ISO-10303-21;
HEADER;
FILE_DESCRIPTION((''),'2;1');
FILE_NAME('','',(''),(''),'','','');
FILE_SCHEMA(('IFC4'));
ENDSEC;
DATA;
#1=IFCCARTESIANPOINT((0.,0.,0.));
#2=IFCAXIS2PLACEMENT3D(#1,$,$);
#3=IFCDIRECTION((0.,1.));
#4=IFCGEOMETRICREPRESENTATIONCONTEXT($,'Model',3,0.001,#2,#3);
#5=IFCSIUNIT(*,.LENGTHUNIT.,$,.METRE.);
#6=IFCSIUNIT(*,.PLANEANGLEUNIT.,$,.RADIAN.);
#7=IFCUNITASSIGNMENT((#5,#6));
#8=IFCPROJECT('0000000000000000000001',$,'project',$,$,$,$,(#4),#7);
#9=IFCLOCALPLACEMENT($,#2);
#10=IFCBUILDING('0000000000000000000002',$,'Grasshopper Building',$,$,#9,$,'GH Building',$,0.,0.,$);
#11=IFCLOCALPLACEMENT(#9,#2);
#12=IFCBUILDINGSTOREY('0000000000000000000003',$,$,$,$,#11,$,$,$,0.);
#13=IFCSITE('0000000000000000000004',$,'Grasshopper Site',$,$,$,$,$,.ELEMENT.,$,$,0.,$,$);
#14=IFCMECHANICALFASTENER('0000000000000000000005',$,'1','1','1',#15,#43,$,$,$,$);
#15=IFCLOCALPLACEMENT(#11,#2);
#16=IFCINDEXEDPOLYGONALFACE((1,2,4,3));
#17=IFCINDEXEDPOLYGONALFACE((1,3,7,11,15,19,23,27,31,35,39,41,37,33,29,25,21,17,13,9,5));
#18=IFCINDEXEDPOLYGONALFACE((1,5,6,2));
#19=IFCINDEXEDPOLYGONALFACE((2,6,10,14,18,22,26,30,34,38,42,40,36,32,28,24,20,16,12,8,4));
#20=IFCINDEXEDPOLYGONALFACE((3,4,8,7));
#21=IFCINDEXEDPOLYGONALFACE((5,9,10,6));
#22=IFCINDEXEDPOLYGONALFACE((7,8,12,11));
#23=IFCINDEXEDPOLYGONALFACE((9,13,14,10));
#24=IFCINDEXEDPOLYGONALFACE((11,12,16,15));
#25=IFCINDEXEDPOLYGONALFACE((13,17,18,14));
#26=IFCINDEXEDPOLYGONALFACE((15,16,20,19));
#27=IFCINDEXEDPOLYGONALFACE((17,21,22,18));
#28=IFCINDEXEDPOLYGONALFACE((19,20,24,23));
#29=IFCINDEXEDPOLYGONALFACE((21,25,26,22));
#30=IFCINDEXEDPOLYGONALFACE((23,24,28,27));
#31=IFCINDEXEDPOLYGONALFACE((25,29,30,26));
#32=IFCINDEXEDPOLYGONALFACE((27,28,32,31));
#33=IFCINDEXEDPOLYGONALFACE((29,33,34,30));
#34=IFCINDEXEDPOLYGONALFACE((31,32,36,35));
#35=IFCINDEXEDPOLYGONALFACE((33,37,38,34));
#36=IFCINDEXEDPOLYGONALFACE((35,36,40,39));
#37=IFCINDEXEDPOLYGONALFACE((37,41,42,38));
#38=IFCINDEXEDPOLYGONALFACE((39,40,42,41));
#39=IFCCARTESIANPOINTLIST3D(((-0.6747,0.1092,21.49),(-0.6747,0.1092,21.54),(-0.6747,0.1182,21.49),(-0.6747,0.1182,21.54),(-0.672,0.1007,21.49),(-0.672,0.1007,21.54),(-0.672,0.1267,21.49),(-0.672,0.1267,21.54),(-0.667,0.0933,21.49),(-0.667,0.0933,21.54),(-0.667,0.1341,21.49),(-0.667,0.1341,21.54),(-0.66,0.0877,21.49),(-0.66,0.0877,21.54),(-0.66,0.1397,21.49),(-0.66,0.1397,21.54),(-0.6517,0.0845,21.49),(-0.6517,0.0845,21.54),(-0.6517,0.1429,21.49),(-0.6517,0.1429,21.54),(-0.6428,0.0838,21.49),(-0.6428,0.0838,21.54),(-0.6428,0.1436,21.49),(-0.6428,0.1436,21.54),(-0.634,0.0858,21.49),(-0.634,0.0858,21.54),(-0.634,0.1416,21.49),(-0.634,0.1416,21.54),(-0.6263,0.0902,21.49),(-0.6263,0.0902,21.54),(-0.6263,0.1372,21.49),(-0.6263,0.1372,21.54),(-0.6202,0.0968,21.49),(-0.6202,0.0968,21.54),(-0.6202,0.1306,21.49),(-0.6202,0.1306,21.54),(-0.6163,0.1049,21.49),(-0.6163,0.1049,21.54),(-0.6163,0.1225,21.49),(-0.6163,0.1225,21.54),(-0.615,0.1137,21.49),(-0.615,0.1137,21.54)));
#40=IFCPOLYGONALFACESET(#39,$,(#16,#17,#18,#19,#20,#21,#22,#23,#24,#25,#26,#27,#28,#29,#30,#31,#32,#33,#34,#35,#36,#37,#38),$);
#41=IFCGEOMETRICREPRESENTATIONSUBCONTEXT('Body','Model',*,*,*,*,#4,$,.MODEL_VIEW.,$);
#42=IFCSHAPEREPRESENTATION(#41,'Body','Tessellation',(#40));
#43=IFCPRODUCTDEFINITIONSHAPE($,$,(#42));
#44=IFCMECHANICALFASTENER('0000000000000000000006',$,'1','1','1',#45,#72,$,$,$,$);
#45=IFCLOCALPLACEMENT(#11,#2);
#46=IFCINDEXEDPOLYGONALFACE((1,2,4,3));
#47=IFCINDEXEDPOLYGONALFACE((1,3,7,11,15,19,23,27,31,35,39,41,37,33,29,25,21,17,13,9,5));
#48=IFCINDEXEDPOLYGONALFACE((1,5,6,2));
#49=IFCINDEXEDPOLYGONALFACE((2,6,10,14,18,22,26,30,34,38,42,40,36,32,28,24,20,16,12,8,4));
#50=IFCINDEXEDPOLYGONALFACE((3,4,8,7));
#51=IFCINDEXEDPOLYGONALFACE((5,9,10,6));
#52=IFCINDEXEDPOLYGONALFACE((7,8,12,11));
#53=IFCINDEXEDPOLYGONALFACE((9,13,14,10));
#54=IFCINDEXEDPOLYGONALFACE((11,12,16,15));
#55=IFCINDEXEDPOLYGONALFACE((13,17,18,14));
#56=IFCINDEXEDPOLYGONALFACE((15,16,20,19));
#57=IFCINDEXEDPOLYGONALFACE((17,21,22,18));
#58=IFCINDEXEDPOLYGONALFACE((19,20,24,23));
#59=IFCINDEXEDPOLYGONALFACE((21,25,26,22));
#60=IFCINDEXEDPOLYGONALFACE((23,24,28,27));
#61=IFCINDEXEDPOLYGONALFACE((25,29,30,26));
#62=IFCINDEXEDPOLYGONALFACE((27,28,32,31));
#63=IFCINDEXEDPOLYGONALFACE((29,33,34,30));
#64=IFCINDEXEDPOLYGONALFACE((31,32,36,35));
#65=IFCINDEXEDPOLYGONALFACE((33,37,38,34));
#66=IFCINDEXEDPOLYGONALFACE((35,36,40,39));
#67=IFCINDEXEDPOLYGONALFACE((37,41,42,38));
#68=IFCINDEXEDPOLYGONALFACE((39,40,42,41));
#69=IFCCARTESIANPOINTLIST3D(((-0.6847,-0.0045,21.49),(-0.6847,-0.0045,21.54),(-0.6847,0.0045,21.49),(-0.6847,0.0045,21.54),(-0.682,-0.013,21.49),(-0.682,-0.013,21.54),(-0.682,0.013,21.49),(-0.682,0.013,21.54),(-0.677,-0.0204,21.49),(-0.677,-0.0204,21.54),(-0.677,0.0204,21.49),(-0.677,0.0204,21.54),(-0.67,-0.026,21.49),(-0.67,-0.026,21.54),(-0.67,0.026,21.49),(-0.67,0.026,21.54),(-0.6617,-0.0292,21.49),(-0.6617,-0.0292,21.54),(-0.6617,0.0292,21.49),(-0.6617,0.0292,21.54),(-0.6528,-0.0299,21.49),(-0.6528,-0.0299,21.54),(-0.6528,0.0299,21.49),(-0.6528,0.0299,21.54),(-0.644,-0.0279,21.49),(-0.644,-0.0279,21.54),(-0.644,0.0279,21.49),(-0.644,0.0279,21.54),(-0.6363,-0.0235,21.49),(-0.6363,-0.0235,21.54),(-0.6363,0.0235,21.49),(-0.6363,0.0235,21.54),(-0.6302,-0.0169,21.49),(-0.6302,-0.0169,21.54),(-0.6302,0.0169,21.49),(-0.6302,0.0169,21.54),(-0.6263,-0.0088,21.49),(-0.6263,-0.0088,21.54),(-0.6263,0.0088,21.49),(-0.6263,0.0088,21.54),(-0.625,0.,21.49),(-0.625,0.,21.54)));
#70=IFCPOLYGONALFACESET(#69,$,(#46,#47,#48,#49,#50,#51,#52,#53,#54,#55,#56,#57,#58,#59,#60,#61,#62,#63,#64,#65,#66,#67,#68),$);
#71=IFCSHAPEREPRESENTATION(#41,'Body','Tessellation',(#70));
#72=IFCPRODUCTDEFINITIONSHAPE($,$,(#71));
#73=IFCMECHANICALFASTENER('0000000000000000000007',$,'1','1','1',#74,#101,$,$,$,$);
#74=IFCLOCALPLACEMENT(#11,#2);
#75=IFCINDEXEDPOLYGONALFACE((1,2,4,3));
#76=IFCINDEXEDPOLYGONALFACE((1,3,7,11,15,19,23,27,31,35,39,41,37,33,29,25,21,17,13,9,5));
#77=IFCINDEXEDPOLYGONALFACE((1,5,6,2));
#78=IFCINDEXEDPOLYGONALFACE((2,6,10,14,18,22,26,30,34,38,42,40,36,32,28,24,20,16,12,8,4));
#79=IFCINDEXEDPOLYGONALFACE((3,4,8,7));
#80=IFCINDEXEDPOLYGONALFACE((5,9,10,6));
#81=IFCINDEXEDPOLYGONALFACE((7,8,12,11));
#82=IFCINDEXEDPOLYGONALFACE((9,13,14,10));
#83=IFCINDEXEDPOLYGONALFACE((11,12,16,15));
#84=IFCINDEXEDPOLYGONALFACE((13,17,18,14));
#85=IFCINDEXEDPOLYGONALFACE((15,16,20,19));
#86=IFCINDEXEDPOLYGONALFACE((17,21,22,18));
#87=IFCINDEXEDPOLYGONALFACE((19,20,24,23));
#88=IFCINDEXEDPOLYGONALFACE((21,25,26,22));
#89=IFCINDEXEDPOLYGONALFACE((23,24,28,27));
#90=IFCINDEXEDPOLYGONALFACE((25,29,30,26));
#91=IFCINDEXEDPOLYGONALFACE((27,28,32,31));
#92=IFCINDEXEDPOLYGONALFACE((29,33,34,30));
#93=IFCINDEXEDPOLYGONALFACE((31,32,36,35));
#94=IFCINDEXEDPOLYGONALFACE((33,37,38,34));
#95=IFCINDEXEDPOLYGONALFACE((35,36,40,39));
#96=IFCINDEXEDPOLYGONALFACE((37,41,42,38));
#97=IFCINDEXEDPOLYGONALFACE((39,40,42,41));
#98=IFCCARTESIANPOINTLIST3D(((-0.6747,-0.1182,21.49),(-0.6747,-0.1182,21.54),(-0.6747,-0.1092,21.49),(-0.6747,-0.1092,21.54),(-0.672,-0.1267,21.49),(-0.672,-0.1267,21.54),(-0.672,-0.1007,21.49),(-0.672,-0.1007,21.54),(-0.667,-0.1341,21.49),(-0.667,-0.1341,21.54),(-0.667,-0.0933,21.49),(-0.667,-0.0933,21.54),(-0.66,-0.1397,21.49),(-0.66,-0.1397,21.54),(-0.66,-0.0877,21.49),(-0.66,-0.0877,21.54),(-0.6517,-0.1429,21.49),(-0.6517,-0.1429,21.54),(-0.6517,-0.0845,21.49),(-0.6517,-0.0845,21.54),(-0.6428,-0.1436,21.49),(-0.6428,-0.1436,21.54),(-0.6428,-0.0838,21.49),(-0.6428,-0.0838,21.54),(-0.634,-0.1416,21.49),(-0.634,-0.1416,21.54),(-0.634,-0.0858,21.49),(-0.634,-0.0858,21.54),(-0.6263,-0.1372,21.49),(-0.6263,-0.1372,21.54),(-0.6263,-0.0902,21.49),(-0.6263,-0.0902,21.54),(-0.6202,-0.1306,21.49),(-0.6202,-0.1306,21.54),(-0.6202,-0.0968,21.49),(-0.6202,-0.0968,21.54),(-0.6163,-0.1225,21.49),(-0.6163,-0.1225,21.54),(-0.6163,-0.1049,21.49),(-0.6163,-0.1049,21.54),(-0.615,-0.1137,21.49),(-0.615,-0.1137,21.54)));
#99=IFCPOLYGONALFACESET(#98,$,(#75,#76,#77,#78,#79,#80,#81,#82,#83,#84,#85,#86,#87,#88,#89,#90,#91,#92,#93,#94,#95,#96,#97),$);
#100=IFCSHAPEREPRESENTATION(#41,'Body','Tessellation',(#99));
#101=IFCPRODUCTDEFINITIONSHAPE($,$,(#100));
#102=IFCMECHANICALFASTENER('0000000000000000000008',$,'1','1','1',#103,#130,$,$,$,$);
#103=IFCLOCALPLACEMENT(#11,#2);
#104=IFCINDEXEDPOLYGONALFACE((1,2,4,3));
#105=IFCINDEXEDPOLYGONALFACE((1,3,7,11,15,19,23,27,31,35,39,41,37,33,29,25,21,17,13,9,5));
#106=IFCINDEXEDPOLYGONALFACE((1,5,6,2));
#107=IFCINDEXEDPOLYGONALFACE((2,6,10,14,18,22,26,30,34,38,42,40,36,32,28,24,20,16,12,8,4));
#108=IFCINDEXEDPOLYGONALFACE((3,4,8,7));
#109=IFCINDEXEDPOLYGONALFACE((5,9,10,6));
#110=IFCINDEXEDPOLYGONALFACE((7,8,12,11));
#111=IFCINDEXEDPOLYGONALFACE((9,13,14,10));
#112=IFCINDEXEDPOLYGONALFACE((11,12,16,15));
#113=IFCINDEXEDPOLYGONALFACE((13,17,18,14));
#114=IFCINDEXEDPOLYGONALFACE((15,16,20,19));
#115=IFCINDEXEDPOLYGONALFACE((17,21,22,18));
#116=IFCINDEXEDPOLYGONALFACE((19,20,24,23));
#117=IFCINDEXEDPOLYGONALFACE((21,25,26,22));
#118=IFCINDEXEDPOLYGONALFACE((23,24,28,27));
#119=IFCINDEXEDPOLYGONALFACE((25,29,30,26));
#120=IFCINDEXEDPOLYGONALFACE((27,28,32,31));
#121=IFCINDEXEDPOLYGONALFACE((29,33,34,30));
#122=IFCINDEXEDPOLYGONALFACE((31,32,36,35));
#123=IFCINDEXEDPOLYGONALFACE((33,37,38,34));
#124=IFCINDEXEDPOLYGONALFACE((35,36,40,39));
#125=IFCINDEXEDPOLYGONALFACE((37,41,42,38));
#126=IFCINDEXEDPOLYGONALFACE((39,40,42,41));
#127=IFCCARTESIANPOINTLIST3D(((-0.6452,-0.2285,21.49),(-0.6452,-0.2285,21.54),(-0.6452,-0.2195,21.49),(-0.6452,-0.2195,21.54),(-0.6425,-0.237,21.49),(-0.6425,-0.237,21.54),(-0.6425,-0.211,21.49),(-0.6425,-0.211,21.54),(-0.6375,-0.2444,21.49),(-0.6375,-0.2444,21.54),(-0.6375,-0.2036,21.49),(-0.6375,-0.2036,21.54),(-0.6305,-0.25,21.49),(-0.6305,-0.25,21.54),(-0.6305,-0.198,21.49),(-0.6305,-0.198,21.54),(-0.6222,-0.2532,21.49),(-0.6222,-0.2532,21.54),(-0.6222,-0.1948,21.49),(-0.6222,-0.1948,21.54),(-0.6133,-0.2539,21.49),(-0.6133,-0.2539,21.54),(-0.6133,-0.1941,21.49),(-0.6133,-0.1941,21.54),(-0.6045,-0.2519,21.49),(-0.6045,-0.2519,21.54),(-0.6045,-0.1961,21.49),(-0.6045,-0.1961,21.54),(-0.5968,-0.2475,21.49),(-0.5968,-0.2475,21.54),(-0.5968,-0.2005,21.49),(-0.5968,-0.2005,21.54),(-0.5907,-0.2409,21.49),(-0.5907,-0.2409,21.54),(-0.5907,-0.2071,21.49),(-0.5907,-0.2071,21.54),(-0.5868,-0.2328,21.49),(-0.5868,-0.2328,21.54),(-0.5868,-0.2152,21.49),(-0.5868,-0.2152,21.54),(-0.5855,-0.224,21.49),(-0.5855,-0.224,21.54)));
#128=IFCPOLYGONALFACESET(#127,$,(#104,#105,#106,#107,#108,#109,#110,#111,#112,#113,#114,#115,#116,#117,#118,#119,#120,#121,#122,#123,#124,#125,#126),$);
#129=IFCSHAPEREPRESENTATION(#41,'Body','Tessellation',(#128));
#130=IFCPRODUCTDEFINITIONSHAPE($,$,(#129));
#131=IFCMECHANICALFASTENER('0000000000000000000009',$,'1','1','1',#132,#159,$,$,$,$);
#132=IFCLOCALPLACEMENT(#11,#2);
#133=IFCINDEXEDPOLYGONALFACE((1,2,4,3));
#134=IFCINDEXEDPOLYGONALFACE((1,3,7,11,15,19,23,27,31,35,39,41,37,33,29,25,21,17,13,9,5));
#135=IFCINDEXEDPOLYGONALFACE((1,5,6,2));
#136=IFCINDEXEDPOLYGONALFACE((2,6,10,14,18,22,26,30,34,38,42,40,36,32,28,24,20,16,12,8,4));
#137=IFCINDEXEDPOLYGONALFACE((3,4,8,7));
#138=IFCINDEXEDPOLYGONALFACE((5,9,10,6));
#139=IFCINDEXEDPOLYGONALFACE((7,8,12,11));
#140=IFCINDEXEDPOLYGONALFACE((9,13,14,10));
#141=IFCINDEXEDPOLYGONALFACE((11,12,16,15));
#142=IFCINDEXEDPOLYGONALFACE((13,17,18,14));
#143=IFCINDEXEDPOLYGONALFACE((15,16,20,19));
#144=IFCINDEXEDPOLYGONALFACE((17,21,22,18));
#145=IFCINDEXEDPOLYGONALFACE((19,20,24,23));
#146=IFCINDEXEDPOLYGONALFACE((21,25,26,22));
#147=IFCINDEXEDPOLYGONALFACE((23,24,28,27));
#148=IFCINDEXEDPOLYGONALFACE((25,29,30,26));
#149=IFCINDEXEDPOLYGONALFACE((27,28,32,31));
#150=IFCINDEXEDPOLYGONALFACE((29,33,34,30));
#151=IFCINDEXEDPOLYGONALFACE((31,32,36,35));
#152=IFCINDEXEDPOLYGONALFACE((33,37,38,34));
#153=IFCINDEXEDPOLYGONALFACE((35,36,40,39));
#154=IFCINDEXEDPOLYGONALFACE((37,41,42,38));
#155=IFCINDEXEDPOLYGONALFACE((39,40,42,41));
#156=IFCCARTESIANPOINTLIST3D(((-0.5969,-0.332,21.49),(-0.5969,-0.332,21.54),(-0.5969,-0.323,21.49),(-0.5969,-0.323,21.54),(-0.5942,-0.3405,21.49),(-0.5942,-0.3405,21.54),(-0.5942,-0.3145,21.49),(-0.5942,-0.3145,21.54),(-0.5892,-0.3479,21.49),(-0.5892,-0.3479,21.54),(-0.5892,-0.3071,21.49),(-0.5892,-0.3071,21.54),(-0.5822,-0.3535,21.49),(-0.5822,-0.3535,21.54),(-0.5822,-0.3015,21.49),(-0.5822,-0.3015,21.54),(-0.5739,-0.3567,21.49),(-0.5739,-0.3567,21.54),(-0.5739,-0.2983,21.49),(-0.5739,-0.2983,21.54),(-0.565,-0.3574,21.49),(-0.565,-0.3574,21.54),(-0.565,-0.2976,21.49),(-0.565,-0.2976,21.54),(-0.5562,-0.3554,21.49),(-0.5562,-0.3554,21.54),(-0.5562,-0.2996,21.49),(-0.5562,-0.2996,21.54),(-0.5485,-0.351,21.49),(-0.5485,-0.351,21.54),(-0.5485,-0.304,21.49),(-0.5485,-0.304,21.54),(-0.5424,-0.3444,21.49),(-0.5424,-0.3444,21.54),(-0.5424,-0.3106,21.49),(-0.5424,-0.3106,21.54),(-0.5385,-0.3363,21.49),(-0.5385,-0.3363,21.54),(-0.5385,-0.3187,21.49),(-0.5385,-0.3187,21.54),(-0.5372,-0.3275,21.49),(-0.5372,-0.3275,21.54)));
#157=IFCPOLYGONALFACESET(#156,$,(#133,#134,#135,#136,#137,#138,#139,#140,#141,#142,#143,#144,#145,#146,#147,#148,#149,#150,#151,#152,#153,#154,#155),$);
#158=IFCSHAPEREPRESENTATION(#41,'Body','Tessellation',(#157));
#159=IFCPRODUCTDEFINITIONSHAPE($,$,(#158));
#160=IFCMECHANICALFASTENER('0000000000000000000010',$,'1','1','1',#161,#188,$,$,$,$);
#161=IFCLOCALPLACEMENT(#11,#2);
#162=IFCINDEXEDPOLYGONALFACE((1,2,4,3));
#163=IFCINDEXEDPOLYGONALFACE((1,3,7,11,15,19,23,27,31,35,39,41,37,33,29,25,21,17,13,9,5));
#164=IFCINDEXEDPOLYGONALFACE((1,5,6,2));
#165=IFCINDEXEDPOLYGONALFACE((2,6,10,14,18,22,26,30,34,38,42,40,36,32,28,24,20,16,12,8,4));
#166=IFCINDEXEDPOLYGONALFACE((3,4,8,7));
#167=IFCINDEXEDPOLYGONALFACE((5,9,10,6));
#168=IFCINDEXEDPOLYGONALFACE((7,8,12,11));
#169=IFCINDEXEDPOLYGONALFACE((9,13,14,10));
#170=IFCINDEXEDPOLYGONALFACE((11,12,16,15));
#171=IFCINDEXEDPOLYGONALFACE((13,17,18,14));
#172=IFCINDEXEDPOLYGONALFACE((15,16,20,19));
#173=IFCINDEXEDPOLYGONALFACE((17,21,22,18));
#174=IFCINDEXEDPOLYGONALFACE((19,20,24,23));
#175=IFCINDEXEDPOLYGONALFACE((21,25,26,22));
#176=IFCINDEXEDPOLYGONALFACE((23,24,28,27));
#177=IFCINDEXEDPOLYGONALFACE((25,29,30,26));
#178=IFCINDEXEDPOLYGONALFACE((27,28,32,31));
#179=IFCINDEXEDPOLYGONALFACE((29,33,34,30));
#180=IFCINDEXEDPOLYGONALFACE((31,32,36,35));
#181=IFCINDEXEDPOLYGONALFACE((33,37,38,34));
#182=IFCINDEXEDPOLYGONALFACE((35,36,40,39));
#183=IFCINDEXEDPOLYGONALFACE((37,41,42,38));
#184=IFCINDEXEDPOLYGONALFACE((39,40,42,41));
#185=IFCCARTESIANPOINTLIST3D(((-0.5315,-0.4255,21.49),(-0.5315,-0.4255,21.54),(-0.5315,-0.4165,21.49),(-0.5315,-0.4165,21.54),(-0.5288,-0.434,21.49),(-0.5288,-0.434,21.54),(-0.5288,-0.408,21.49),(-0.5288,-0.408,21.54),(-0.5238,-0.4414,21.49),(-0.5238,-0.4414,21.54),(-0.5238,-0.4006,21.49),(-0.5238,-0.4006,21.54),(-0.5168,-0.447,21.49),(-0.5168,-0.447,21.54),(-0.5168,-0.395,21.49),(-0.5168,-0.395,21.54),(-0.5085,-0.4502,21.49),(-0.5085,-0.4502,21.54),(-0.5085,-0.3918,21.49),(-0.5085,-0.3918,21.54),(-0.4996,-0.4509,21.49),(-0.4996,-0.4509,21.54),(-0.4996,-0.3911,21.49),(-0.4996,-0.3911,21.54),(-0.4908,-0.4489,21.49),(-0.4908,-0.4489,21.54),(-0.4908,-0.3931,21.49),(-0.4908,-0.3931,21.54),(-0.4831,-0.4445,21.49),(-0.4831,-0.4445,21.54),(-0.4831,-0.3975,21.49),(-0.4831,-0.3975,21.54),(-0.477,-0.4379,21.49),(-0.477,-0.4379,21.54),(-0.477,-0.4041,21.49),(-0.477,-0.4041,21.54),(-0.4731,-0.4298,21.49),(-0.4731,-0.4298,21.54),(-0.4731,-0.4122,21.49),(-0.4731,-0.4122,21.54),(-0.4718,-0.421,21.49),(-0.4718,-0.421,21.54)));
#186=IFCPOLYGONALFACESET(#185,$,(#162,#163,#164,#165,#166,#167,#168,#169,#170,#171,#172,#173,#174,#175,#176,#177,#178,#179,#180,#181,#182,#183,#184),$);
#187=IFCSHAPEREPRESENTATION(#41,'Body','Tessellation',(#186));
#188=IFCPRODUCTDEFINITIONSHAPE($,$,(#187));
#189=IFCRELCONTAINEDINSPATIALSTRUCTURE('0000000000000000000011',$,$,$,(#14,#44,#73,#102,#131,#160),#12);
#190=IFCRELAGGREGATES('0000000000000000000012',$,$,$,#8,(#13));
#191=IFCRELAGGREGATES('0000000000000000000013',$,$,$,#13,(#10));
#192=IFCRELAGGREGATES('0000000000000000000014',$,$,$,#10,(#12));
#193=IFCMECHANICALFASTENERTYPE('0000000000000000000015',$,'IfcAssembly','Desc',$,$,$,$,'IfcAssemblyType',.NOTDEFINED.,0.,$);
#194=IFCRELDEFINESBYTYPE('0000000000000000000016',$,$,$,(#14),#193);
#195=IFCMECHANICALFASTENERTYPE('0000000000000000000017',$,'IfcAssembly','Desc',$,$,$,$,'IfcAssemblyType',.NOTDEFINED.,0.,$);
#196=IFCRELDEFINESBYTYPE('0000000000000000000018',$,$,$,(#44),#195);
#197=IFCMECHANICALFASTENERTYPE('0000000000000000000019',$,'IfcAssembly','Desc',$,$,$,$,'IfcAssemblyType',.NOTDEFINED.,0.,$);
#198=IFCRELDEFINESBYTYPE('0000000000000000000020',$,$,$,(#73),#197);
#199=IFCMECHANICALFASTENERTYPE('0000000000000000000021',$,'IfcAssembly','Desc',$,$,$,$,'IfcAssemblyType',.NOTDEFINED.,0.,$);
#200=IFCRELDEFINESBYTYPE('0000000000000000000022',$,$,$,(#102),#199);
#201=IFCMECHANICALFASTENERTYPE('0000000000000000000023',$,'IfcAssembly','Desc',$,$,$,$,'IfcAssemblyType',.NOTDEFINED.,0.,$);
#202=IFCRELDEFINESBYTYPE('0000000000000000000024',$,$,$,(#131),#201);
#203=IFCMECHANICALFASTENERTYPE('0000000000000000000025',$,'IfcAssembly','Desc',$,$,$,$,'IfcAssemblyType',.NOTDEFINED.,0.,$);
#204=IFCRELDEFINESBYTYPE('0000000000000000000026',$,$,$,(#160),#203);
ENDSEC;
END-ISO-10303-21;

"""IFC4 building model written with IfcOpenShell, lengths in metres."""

from ifc_helpers import new_model, si_unit, direction, frame, origin, place, context, subcontext, project, spatial, circle, extrude, source, transform, mapped, type_object, type_shapes, element, save


model = new_model("IFC4")

# Units and contexts
model_context = context("Model", 3, precision=0.001, world=origin(), true_north=direction((0.0, 1.0)))
body_context = subcontext(model_context, "Body", "Model", "MODEL_VIEW")
ifc_project = project(units=[si_unit("LENGTHUNIT", "METRE"), si_unit("PLANEANGLEUNIT", "RADIAN")], contexts=[model_context])

# Site, building, storey
site = spatial("IfcSite", under=ifc_project, Name="Grasshopper Site", CompositionType="ELEMENT", RefElevation=0.0)
building_placement = place(None, origin())
building = spatial("IfcBuilding", under=site, at=building_placement, Name="Grasshopper Building", LongName="GH Building", ElevationOfRefHeight=0.0, ElevationOfTerrain=0.0)
storey_placement = place(building_placement, origin())
storey = spatial("IfcBuildingStorey", under=building, at=storey_placement, Elevation=0.0)

# Mechanical fasteners
mechanical_fastener_type_1 = type_object("IfcMechanicalFastenerType", Name="IfcAssembly", Description="Desc", ElementType="IfcAssemblyType", NominalDiameter=0.0)
shared_shape_1 = source(origin(), body_context, "Body", "SweptSolid", [
    extrude(circle(Radius=0.03), frame((-0.645, 0.1137, 21.54), z_axis=(0.0, 0.0, -1.0), x_axis=(1.0, 0.0, 0.0)), (0.0, 0.0, 1.0), 0.05),
])
type_shapes(mechanical_fastener_type_1, [shared_shape_1])
mechanical_fastener_1_placement = place(storey_placement, origin())
element("IfcMechanicalFastener", 1, at=mechanical_fastener_1_placement, inside=storey, type_object=mechanical_fastener_type_1, Name="1", Description="1", ObjectType="1", context=body_context, shape_type="MappedRepresentation", body=[
    mapped(shared_shape_1, transform((0.0, 0.0, 0.0), scale=1.0)),
])
mechanical_fastener_type_2 = type_object("IfcMechanicalFastenerType", Name="IfcAssembly", Description="Desc", ElementType="IfcAssemblyType", NominalDiameter=0.0)
shared_shape_2 = source(origin(), body_context, "Body", "SweptSolid", [
    extrude(circle(Radius=0.03), frame((-0.655, 0.0, 21.54), z_axis=(0.0, 0.0, -1.0), x_axis=(1.0, 0.0, 0.0)), (0.0, 0.0, 1.0), 0.05),
])
type_shapes(mechanical_fastener_type_2, [shared_shape_2])
mechanical_fastener_2_placement = place(storey_placement, origin())
element("IfcMechanicalFastener", 2, at=mechanical_fastener_2_placement, inside=storey, type_object=mechanical_fastener_type_2, Name="1", Description="1", ObjectType="1", context=body_context, shape_type="MappedRepresentation", body=[
    mapped(shared_shape_2, transform((0.0, 0.0, 0.0), scale=1.0)),
])
mechanical_fastener_type_3 = type_object("IfcMechanicalFastenerType", Name="IfcAssembly", Description="Desc", ElementType="IfcAssemblyType", NominalDiameter=0.0)
shared_shape_3 = source(origin(), body_context, "Body", "SweptSolid", [
    extrude(circle(Radius=0.03), frame((-0.645, -0.1137, 21.54), z_axis=(0.0, 0.0, -1.0), x_axis=(1.0, 0.0, 0.0)), (0.0, 0.0, 1.0), 0.05),
])
type_shapes(mechanical_fastener_type_3, [shared_shape_3])
mechanical_fastener_3_placement = place(storey_placement, origin())
element("IfcMechanicalFastener", 3, at=mechanical_fastener_3_placement, inside=storey, type_object=mechanical_fastener_type_3, Name="1", Description="1", ObjectType="1", context=body_context, shape_type="MappedRepresentation", body=[
    mapped(shared_shape_3, transform((0.0, 0.0, 0.0), scale=1.0)),
])
mechanical_fastener_type_4 = type_object("IfcMechanicalFastenerType", Name="IfcAssembly", Description="Desc", ElementType="IfcAssemblyType", NominalDiameter=0.0)
shared_shape_4 = source(origin(), body_context, "Body", "SweptSolid", [
    extrude(circle(Radius=0.03), frame((-0.6155, -0.224, 21.54), z_axis=(0.0, 0.0, -1.0), x_axis=(1.0, 0.0, 0.0)), (0.0, 0.0, 1.0), 0.05),
])
type_shapes(mechanical_fastener_type_4, [shared_shape_4])
mechanical_fastener_4_placement = place(storey_placement, origin())
element("IfcMechanicalFastener", 4, at=mechanical_fastener_4_placement, inside=storey, type_object=mechanical_fastener_type_4, Name="1", Description="1", ObjectType="1", context=body_context, shape_type="MappedRepresentation", body=[
    mapped(shared_shape_4, transform((0.0, 0.0, 0.0), scale=1.0)),
])
mechanical_fastener_type_5 = type_object("IfcMechanicalFastenerType", Name="IfcAssembly", Description="Desc", ElementType="IfcAssemblyType", NominalDiameter=0.0)
shared_shape_5 = source(origin(), body_context, "Body", "SweptSolid", [
    extrude(circle(Radius=0.03), frame((-0.5672, -0.3275, 21.54), z_axis=(0.0, 0.0, -1.0), x_axis=(1.0, 0.0, 0.0)), (0.0, 0.0, 1.0), 0.05),
])
type_shapes(mechanical_fastener_type_5, [shared_shape_5])
mechanical_fastener_5_placement = place(storey_placement, origin())
element("IfcMechanicalFastener", 5, at=mechanical_fastener_5_placement, inside=storey, type_object=mechanical_fastener_type_5, Name="1", Description="1", ObjectType="1", context=body_context, shape_type="MappedRepresentation", body=[
    mapped(shared_shape_5, transform((0.0, 0.0, 0.0), scale=1.0)),
])
mechanical_fastener_type_6 = type_object("IfcMechanicalFastenerType", Name="IfcAssembly", Description="Desc", ElementType="IfcAssemblyType", NominalDiameter=0.0)
shared_shape_6 = source(origin(), body_context, "Body", "SweptSolid", [
    extrude(circle(Radius=0.03), frame((-0.5018, -0.421, 21.54), z_axis=(0.0, 0.0, -1.0), x_axis=(1.0, 0.0, 0.0)), (0.0, 0.0, 1.0), 0.05),
])
type_shapes(mechanical_fastener_type_6, [shared_shape_6])
mechanical_fastener_6_placement = place(storey_placement, origin())
element("IfcMechanicalFastener", 6, at=mechanical_fastener_6_placement, inside=storey, type_object=mechanical_fastener_type_6, Name="1", Description="1", ObjectType="1", context=body_context, shape_type="MappedRepresentation", body=[
    mapped(shared_shape_6, transform((0.0, 0.0, 0.0), scale=1.0)),
])

save(model, "model.ifc")
